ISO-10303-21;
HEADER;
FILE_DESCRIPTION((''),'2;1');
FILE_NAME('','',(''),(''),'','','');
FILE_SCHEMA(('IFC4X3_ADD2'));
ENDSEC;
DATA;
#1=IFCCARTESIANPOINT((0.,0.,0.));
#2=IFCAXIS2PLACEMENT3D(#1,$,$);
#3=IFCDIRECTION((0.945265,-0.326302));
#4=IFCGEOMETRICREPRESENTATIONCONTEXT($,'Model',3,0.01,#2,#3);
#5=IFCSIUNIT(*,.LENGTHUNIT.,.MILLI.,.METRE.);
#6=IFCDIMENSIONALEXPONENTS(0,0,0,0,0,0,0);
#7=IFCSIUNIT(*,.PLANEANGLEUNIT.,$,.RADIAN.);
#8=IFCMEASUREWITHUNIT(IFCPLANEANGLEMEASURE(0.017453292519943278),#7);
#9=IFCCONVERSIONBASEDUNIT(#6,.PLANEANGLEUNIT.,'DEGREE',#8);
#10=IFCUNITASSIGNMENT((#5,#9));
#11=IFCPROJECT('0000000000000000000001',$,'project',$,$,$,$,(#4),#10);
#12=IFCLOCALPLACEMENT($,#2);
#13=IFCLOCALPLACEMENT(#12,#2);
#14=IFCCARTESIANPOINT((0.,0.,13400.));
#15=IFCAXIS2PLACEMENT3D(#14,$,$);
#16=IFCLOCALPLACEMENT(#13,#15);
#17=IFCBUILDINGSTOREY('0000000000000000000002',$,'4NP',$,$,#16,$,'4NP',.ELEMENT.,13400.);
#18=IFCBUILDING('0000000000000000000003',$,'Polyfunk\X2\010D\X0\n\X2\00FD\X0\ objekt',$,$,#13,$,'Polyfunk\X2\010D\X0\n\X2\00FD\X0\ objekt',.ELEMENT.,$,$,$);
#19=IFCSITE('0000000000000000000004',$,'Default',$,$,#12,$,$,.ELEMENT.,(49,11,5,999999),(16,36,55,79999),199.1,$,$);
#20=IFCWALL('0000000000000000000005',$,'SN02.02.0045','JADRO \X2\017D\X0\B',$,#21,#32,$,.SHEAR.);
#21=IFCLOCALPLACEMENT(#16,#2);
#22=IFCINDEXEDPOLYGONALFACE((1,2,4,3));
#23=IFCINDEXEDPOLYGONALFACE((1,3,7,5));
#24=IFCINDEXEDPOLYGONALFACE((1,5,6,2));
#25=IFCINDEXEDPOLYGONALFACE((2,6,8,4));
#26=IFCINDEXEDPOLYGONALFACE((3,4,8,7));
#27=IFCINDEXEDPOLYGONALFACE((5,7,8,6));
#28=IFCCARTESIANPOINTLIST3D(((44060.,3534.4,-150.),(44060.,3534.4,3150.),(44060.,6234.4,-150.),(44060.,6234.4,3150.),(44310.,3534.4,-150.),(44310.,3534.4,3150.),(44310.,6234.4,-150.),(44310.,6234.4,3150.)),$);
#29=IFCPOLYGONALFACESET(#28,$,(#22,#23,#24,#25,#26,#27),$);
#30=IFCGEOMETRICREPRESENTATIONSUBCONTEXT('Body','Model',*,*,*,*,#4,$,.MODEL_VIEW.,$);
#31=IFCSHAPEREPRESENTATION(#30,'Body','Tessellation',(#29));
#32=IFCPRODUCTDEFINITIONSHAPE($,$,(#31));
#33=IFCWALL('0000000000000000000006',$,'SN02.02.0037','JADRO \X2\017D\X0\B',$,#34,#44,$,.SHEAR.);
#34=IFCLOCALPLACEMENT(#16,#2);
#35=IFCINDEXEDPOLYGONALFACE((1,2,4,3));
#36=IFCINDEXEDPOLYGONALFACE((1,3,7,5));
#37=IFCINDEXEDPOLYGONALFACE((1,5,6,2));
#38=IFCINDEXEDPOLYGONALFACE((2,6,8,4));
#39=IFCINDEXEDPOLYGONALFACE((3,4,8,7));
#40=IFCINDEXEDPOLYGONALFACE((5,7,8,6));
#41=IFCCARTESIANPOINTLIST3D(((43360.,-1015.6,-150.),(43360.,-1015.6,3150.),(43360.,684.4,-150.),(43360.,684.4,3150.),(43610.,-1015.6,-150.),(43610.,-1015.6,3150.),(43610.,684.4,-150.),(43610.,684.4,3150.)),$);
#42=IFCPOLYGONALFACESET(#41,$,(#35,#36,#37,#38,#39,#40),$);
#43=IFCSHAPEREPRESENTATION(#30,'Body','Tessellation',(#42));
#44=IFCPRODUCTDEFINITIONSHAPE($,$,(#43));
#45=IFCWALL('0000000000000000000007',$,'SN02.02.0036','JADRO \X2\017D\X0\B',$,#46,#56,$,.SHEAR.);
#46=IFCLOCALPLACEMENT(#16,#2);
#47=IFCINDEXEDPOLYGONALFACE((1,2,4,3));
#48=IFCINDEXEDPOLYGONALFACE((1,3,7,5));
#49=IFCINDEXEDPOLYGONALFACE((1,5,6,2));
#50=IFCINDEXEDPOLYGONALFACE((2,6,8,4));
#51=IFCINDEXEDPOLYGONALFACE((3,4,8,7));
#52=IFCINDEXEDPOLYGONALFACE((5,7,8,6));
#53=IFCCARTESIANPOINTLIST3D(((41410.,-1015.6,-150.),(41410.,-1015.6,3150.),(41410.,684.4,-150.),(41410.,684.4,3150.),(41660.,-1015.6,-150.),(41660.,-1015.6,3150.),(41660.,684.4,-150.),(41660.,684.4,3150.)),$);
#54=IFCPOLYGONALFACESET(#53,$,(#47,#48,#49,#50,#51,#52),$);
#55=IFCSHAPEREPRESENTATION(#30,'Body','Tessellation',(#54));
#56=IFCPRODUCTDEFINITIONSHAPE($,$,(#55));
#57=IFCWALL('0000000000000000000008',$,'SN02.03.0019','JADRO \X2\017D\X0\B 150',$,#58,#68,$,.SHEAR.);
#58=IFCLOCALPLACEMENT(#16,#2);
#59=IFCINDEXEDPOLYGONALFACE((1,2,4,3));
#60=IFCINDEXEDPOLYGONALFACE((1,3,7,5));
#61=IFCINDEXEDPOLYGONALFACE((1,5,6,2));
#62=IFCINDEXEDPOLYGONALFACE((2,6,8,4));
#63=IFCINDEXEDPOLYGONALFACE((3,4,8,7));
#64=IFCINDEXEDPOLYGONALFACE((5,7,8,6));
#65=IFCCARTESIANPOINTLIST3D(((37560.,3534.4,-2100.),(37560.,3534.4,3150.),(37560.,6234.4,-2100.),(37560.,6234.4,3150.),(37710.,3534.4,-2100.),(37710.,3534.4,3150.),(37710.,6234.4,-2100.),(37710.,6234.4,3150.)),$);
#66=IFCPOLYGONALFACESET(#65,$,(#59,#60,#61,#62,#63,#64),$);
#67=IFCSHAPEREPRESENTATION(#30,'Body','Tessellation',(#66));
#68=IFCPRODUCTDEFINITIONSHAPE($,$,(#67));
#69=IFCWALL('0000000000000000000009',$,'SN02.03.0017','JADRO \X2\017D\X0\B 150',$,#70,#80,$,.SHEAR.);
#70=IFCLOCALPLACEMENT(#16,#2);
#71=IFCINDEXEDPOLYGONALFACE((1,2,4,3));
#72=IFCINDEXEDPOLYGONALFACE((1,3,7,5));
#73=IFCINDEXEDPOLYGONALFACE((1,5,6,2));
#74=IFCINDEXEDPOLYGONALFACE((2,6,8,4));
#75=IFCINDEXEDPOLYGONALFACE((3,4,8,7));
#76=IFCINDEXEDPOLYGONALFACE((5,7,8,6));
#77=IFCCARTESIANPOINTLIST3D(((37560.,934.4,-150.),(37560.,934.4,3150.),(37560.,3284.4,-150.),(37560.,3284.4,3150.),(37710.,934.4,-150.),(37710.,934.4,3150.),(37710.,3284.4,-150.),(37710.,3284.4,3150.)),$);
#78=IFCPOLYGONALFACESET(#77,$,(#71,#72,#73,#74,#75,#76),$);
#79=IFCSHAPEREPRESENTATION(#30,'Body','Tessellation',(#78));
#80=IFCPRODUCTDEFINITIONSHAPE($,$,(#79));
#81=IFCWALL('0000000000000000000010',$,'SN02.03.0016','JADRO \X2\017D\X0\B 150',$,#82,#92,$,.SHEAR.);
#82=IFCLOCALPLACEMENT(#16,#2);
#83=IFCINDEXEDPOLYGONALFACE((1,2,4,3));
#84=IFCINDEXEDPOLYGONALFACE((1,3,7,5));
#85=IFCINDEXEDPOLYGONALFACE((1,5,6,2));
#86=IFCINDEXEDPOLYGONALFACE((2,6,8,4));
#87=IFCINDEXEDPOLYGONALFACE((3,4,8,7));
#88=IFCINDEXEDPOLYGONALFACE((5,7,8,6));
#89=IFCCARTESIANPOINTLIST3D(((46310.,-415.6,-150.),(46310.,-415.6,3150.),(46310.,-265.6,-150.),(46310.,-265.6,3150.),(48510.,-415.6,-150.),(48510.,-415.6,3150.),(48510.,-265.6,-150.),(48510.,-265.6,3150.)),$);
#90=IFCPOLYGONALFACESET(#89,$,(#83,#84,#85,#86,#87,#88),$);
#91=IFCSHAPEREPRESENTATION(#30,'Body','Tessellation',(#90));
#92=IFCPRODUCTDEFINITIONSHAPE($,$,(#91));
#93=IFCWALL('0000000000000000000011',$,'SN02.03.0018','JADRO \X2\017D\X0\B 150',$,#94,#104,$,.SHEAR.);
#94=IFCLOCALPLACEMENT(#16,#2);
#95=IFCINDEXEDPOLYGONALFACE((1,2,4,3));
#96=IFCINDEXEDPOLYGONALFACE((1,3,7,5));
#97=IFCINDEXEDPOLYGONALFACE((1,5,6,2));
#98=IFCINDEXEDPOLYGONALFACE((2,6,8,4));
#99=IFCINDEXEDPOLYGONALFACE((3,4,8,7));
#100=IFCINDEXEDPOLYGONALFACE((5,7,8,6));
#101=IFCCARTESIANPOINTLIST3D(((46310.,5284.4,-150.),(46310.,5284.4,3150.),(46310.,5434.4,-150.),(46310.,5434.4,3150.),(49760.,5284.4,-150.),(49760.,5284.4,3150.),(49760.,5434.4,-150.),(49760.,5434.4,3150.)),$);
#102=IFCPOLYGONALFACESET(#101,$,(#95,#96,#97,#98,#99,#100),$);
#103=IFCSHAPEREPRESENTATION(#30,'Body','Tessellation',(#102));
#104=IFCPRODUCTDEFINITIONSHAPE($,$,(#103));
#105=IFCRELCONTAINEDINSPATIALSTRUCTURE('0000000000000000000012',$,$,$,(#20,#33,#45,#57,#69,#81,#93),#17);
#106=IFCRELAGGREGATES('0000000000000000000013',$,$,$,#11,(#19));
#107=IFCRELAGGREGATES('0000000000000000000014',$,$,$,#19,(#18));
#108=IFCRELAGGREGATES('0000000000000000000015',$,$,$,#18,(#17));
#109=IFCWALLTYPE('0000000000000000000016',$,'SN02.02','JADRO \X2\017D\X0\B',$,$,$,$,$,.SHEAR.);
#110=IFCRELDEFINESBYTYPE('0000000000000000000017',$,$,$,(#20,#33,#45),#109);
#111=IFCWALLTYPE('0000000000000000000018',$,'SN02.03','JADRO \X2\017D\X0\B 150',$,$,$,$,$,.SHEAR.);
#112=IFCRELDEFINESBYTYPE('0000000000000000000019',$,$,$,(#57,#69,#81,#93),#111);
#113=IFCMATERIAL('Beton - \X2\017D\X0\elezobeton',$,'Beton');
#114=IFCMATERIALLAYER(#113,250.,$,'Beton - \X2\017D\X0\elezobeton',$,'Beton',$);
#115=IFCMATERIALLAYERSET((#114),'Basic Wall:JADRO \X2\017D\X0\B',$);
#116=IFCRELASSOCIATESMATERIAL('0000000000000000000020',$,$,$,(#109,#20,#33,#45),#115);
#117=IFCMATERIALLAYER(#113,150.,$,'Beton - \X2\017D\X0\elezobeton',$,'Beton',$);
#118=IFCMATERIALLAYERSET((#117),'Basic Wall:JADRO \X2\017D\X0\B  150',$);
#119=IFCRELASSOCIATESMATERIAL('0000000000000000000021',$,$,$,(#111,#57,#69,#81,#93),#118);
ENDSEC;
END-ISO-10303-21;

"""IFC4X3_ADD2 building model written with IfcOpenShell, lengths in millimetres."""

from ifc_helpers import new_model, entity, si_unit, converted_unit, direction, frame, frame_2d, origin, place, context, subcontext, project, spatial, polyline, rectangle, extrude, clip, bounded_halfspace, material, layer, layer_set, type_object, element, save


model = new_model("IFC4X3_ADD2")

# Units and contexts
model_context = context("Model", 3, precision=0.01, world=origin(), true_north=direction((0.945265, -0.326302)))
body_context = subcontext(model_context, "Body", "Model", "MODEL_VIEW")
ifc_project = project(units=[si_unit("LENGTHUNIT", "METRE", prefix="MILLI"), converted_unit("PLANEANGLEUNIT", "DEGREE", entity("IfcPlaneAngleMeasure", 0.017453292519943278), si_unit("PLANEANGLEUNIT", "RADIAN"), dimensions=[0, 0, 0, 0, 0, 0, 0])], contexts=[model_context])

# Site, building, storey
site_placement = place(None, origin())
site = spatial("IfcSite", under=ifc_project, at=site_placement, Name="Default", CompositionType="ELEMENT", RefLatitude=(49, 11, 5, 999999), RefLongitude=(16, 36, 55, 79999), RefElevation=199.1)
building_placement = place(site_placement, origin())
building = spatial("IfcBuilding", under=site, at=building_placement, Name="Polyfunkčný objekt", LongName="Polyfunkčný objekt", CompositionType="ELEMENT")
storey_placement = place(building_placement, frame((0.0, 0.0, 13400.0)))
storey = spatial("IfcBuildingStorey", under=building, at=storey_placement, Name="4NP", LongName="4NP", CompositionType="ELEMENT", Elevation=13400.0)

# Walls
ifc_material_1 = material(Name="Beton - Železobeton", Category="Beton")
ifc_layer_1 = layer(ifc_material_1, 250.0, Name="Beton - Železobeton", Category="Beton")
ifc_layer_set_1 = layer_set([ifc_layer_1], Name="Basic Wall:JADRO ŽB")
wall_type_1 = type_object("IfcWallType", Name="SN02.02", Description="JADRO ŽB", PredefinedType="SHEAR", material=ifc_layer_set_1)
placement_1 = place(building_placement, frame((0.0, 0.0, 9200.0)))
wall_1_placement = place(placement_1, frame((44185.0, 6234.4, 4050.0), z_axis=(0.0, 0.0, 1.0), x_axis=(0.0, -1.0, 0.0)))
element("IfcWall", 1, at=wall_1_placement, inside=storey, type_object=wall_type_1, material=ifc_layer_set_1, Name="SN02.02.0045", Description="JADRO ŽB", PredefinedType="SHEAR", context=body_context, shape_type="Clipping", body=[
    clip(clip(extrude(rectangle(XDim=2700.0, YDim=250.0, at=frame_2d((1350.0, 0.0), x_axis=(-1.0, 0.0))), origin(), (0.0, 0.0, 1.0), 3300.0), bounded_halfspace(frame((2700.0, -125.0, 0.0), z_axis=(0.0, 0.0, 1.0), x_axis=(0.0, -1.0, 0.0)), True, frame((2700.0, -125.0, 0.0)), polyline([(0.0, 0.0), (0.0, 250.0), (-2700.0, 250.0), (-2700.0, 0.0), (0.0, 0.0)]))), bounded_halfspace(frame((0.0, -125.0, 3300.0), z_axis=(0.0, 0.0, -1.0), x_axis=(1.0, 0.0, 0.0)), True, frame((0.0, -125.0, 3300.0)), polyline([(0.0, 0.0), (2700.0, 0.0), (2700.0, 250.0), (0.0, 250.0), (0.0, 0.0)]))),
])
wall_2_placement = place(placement_1, frame((43485.0, 684.4, 4050.0), z_axis=(0.0, 0.0, 1.0), x_axis=(0.0, -1.0, 0.0)))
element("IfcWall", 2, at=wall_2_placement, inside=storey, type_object=wall_type_1, material=ifc_layer_set_1, Name="SN02.02.0037", Description="JADRO ŽB", PredefinedType="SHEAR", context=body_context, shape_type="Clipping", body=[
    clip(clip(extrude(rectangle(XDim=1700.0, YDim=250.0, at=frame_2d((850.0, 0.0), x_axis=(-1.0, 0.0))), origin(), (0.0, 0.0, 1.0), 3300.0), bounded_halfspace(frame((1700.0, -125.0, 0.0), z_axis=(0.0, 0.0, 1.0), x_axis=(0.0, -1.0, 0.0)), True, frame((1700.0, -125.0, 0.0)), polyline([(0.0, 0.0), (0.0, 250.0), (-1700.0, 250.0), (-1700.0, 0.0), (0.0, 0.0)]))), bounded_halfspace(frame((0.0, -125.0, 3300.0), z_axis=(0.0, 0.0, -1.0), x_axis=(1.0, 0.0, 0.0)), True, frame((0.0, -125.0, 3300.0)), polyline([(0.0, 0.0), (1700.0, 0.0), (1700.0, 250.0), (0.0, 250.0), (0.0, 0.0)]))),
])
wall_3_placement = place(placement_1, frame((41535.0, 684.4, 4050.0), z_axis=(0.0, 0.0, 1.0), x_axis=(0.0, -1.0, 0.0)))
element("IfcWall", 3, at=wall_3_placement, inside=storey, type_object=wall_type_1, material=ifc_layer_set_1, Name="SN02.02.0036", Description="JADRO ŽB", PredefinedType="SHEAR", context=body_context, shape_type="Clipping", body=[
    clip(clip(extrude(rectangle(XDim=1700.0, YDim=250.0, at=frame_2d((850.0, 0.0), x_axis=(-1.0, 0.0))), origin(), (0.0, 0.0, 1.0), 3300.0), bounded_halfspace(frame((1700.0, -125.0, 0.0), z_axis=(0.0, 0.0, 1.0), x_axis=(0.0, -1.0, 0.0)), True, frame((1700.0, -125.0, 0.0)), polyline([(0.0, 0.0), (0.0, 250.0), (-1700.0, 250.0), (-1700.0, 0.0), (0.0, 0.0)]))), bounded_halfspace(frame((0.0, -125.0, 3300.0), z_axis=(0.0, 0.0, -1.0), x_axis=(1.0, 0.0, 0.0)), True, frame((0.0, -125.0, 3300.0)), polyline([(0.0, 0.0), (1700.0, 0.0), (1700.0, 250.0), (0.0, 250.0), (0.0, 0.0)]))),
])
ifc_layer_2 = layer(ifc_material_1, 150.0, Name="Beton - Železobeton", Category="Beton")
ifc_layer_set_2 = layer_set([ifc_layer_2], Name="Basic Wall:JADRO ŽB  150")
wall_type_2 = type_object("IfcWallType", Name="SN02.03", Description="JADRO ŽB 150", PredefinedType="SHEAR", material=ifc_layer_set_2)
wall_4_placement = place(storey_placement, frame((37635.0, 6234.4, -2100.0), z_axis=(0.0, 0.0, 1.0), x_axis=(0.0, -1.0, 0.0)))
element("IfcWall", 4, at=wall_4_placement, inside=storey, type_object=wall_type_2, material=ifc_layer_set_2, Name="SN02.03.0019", Description="JADRO ŽB 150", PredefinedType="SHEAR", context=body_context, shape_type="SweptSolid", body=[
    extrude(rectangle(XDim=2700.0, YDim=150.0, at=frame_2d((1350.0, 0.0), x_axis=(-1.0, 0.0))), origin(), (0.0, 0.0, 1.0), 5250.0),
])
wall_5_placement = place(placement_1, frame((37635.0, 3284.4, 4050.0), z_axis=(0.0, 0.0, 1.0), x_axis=(0.0, -1.0, 0.0)))
element("IfcWall", 5, at=wall_5_placement, inside=storey, type_object=wall_type_2, material=ifc_layer_set_2, Name="SN02.03.0017", Description="JADRO ŽB 150", PredefinedType="SHEAR", context=body_context, shape_type="SweptSolid", body=[
    extrude(rectangle(XDim=2350.0, YDim=150.0, at=frame_2d((1175.0, 0.0), x_axis=(-1.0, 0.0))), origin(), (0.0, 0.0, 1.0), 3300.0),
])
wall_6_placement = place(placement_1, frame((46310.0, -340.6, 4050.0)))
element("IfcWall", 6, at=wall_6_placement, inside=storey, type_object=wall_type_2, material=ifc_layer_set_2, Name="SN02.03.0016", Description="JADRO ŽB 150", PredefinedType="SHEAR", context=body_context, shape_type="Clipping", body=[
    clip(extrude(rectangle(XDim=2200.0, YDim=150.0, at=frame_2d((1100.0, 0.0), x_axis=(-1.0, 0.0))), origin(), (0.0, 0.0, 1.0), 3300.0), bounded_halfspace(frame((2200.0, -75.0, 0.0), z_axis=(0.0, 0.0, 1.0), x_axis=(-1.0, 0.0, 0.0)), True, frame((2200.0, -75.0, 0.0)), polyline([(0.0, 0.0), (0.0, 150.0), (-2200.0, 150.0), (-2200.0, 0.0), (-150.0, 0.0), (0.0, 0.0)]))),
])
wall_7_placement = place(placement_1, frame((46310.0, 5359.4, 4050.0)))
element("IfcWall", 7, at=wall_7_placement, inside=storey, type_object=wall_type_2, material=ifc_layer_set_2, Name="SN02.03.0018", Description="JADRO ŽB 150", PredefinedType="SHEAR", context=body_context, shape_type="SweptSolid", body=[
    extrude(rectangle(XDim=3450.0, YDim=150.0, at=frame_2d((1725.0, 0.0), x_axis=(-1.0, 0.0))), origin(), (0.0, 0.0, 1.0), 3300.0),
])

save(model, "model.ifc")
